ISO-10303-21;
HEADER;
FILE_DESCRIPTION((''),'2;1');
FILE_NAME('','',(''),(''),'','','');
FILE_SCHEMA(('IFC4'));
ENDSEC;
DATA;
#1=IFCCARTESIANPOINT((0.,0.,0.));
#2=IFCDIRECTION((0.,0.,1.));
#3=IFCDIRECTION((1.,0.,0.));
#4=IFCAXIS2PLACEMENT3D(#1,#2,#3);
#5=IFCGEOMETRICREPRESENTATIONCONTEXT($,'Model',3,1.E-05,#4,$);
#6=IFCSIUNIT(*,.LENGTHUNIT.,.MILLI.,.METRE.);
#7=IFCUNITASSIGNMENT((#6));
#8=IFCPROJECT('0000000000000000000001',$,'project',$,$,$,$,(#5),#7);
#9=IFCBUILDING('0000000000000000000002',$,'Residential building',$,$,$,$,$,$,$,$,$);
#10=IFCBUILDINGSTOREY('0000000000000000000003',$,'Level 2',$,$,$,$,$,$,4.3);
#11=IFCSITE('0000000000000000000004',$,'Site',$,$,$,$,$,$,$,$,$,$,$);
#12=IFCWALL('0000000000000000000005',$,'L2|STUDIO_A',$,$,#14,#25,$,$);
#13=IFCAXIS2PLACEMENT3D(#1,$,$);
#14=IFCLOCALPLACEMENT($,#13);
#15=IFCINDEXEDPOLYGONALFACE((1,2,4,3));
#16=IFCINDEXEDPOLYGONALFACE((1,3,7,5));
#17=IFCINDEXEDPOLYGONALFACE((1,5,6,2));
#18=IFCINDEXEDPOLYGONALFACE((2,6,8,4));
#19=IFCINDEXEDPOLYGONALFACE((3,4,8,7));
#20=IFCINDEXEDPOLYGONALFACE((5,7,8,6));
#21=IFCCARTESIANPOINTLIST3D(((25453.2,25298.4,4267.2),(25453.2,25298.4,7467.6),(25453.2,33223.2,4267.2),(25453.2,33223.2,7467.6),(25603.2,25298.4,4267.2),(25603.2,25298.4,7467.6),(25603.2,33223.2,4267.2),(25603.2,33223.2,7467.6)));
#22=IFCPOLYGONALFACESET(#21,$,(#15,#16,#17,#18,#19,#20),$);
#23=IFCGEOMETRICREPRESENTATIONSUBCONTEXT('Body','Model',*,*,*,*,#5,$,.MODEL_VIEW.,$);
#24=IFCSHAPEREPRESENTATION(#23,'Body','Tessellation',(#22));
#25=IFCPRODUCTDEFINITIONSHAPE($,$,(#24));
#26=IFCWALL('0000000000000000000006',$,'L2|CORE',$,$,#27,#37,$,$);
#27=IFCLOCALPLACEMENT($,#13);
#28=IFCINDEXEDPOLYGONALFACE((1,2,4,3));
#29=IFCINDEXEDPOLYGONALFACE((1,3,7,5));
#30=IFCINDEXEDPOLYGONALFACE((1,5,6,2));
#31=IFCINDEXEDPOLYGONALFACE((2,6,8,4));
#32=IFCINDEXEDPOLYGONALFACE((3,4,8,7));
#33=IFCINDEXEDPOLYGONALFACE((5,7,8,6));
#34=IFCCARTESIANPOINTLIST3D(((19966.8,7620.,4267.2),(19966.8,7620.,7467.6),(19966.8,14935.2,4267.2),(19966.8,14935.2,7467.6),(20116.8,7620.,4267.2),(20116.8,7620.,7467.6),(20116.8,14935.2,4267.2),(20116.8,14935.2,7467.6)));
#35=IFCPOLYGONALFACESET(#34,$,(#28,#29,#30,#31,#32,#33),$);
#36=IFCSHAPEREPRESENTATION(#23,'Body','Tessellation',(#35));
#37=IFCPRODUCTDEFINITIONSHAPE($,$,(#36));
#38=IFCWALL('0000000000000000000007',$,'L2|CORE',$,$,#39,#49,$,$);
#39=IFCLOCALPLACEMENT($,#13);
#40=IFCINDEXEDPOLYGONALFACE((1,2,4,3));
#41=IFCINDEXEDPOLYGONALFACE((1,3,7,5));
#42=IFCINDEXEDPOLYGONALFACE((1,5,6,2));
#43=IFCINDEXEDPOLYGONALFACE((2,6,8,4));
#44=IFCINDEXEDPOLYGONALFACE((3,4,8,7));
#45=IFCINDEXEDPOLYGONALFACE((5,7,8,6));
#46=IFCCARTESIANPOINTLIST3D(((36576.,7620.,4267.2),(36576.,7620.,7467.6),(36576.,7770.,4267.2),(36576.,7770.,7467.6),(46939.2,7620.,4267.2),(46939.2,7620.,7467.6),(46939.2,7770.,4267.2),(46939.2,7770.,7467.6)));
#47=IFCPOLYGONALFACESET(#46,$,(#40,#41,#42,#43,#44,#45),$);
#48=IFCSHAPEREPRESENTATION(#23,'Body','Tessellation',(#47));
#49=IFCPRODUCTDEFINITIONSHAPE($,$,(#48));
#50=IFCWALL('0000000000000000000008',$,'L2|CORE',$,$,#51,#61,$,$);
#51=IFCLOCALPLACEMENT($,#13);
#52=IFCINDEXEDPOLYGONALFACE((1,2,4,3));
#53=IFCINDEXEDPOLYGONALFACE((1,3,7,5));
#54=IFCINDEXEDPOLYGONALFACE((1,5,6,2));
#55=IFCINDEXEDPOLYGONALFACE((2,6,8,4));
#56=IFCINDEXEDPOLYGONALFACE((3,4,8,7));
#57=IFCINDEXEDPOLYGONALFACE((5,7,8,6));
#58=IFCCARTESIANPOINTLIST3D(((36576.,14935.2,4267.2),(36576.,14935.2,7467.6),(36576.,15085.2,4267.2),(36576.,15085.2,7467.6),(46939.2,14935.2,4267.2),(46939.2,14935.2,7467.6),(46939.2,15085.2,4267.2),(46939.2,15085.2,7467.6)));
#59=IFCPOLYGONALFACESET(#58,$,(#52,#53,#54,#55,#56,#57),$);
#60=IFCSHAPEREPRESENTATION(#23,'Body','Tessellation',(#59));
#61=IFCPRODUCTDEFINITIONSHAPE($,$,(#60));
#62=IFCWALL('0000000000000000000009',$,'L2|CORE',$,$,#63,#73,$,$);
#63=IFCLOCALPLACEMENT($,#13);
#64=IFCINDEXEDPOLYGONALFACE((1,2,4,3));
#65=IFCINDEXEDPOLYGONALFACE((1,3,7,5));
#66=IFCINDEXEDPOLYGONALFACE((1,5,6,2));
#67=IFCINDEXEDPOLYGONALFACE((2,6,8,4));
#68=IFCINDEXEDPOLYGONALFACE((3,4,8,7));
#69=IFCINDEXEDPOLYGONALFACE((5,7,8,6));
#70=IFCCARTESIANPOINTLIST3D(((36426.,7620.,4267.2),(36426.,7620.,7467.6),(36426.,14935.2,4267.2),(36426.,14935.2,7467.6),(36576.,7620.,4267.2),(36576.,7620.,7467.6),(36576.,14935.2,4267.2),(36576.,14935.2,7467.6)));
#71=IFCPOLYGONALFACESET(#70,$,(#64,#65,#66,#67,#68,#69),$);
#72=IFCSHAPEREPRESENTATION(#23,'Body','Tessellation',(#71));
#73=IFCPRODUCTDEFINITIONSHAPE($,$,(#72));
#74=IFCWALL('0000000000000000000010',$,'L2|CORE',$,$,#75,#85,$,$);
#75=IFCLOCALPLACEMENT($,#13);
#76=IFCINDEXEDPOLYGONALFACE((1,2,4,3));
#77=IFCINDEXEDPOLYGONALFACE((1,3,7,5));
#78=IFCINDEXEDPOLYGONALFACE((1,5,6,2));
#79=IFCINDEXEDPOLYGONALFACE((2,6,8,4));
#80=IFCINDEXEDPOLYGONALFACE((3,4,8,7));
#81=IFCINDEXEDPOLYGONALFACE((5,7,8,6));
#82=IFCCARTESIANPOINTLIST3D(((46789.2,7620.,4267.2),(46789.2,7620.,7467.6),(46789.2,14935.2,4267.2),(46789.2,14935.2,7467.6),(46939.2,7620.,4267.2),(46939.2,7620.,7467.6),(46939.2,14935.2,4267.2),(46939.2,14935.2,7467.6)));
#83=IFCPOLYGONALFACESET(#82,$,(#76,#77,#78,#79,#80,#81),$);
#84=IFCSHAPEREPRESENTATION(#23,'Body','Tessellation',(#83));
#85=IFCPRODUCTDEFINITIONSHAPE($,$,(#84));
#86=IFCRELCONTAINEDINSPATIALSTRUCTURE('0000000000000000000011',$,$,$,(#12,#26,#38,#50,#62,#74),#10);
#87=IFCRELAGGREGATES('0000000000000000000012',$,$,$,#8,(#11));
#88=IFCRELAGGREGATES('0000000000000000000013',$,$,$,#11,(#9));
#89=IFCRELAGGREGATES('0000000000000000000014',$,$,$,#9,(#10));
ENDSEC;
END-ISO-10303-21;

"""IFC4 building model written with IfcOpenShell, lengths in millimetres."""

from ifc_helpers import new_model, si_unit, frame, origin_with_axes, place, context, subcontext, project, spatial, indexed_curve, outline, extrude, element, save


model = new_model("IFC4")

# Units and contexts
model_context = context("Model", 3, precision=1e-05, world=origin_with_axes())
body_context = subcontext(model_context, "Body", "Model", "MODEL_VIEW")
ifc_project = project(units=[si_unit("LENGTHUNIT", "METRE", prefix="MILLI")], contexts=[model_context])

# Site, building, storey
site = spatial("IfcSite", under=ifc_project, Name="Site")
building = spatial("IfcBuilding", under=site, Name="Residential building")
storey = spatial("IfcBuildingStorey", under=building, Name="Level 2", Elevation=4.3)

# Walls
wall_1_placement = place(None, frame((25603.2, 25298.4, 4267.2), z_axis=(0.0, 0.0, 1.0), x_axis=(0.0, 1.0, 0.0)))
element("IfcWall", 1, at=wall_1_placement, inside=storey, Name="L2|STUDIO_A", context=body_context, shape_type="SweptSolid", body=[
    extrude(outline(indexed_curve([(0.0, 0.0), (0.0, 150.0), (7924.8, 150.0), (7924.8, 0.0), (0.0, 0.0)], self_intersect=False)), origin_with_axes(), (0.0, 0.0, 1.0), 3200.4),
])
wall_2_placement = place(None, frame((20116.8, 7620.0, 4267.2), z_axis=(0.0, 0.0, 1.0), x_axis=(0.0, 1.0, 0.0)))
element("IfcWall", 2, at=wall_2_placement, inside=storey, Name="L2|CORE", context=body_context, shape_type="SweptSolid", body=[
    extrude(outline(indexed_curve([(0.0, 0.0), (0.0, 150.0), (7315.2, 150.0), (7315.2, 0.0), (0.0, 0.0)], self_intersect=False)), origin_with_axes(), (0.0, 0.0, 1.0), 3200.4),
])
for number, where, z_axis, x_axis, name in (
    (3, (36576.0, 7620.0, 4267.2), (0.0, 0.0, 1.0), (1.0, 0.0, 0.0), "L2|CORE"),
    (4, (36576.0, 14935.2, 4267.2), (0.0, 0.0, 1.0), (1.0, 0.0, 0.0), "L2|CORE"),
):
    element("IfcWall", number, at=place(None, frame(where, z_axis=z_axis, x_axis=x_axis)), inside=storey, Name=name, context=body_context, shape_type="SweptSolid", body=[
        extrude(outline(indexed_curve([(0.0, 0.0), (0.0, 150.0), (10363.2, 150.0), (10363.2, 0.0), (0.0, 0.0)], self_intersect=False)), origin_with_axes(), (0.0, 0.0, 1.0), 3200.4),
    ])
for number, where, z_axis, x_axis, name in (
    (5, (36576.0, 7620.0, 4267.2), (0.0, 0.0, 1.0), (0.0, 1.0, 0.0), "L2|CORE"),
    (6, (46939.2, 7620.0, 4267.2), (0.0, 0.0, 1.0), (0.0, 1.0, 0.0), "L2|CORE"),
):
    element("IfcWall", number, at=place(None, frame(where, z_axis=z_axis, x_axis=x_axis)), inside=storey, Name=name, context=body_context, shape_type="SweptSolid", body=[
        extrude(outline(indexed_curve([(0.0, 0.0), (0.0, 150.0), (7315.2, 150.0), (7315.2, 0.0), (0.0, 0.0)], self_intersect=False)), origin_with_axes(), (0.0, 0.0, 1.0), 3200.4),
    ])

save(model, "model.ifc")
